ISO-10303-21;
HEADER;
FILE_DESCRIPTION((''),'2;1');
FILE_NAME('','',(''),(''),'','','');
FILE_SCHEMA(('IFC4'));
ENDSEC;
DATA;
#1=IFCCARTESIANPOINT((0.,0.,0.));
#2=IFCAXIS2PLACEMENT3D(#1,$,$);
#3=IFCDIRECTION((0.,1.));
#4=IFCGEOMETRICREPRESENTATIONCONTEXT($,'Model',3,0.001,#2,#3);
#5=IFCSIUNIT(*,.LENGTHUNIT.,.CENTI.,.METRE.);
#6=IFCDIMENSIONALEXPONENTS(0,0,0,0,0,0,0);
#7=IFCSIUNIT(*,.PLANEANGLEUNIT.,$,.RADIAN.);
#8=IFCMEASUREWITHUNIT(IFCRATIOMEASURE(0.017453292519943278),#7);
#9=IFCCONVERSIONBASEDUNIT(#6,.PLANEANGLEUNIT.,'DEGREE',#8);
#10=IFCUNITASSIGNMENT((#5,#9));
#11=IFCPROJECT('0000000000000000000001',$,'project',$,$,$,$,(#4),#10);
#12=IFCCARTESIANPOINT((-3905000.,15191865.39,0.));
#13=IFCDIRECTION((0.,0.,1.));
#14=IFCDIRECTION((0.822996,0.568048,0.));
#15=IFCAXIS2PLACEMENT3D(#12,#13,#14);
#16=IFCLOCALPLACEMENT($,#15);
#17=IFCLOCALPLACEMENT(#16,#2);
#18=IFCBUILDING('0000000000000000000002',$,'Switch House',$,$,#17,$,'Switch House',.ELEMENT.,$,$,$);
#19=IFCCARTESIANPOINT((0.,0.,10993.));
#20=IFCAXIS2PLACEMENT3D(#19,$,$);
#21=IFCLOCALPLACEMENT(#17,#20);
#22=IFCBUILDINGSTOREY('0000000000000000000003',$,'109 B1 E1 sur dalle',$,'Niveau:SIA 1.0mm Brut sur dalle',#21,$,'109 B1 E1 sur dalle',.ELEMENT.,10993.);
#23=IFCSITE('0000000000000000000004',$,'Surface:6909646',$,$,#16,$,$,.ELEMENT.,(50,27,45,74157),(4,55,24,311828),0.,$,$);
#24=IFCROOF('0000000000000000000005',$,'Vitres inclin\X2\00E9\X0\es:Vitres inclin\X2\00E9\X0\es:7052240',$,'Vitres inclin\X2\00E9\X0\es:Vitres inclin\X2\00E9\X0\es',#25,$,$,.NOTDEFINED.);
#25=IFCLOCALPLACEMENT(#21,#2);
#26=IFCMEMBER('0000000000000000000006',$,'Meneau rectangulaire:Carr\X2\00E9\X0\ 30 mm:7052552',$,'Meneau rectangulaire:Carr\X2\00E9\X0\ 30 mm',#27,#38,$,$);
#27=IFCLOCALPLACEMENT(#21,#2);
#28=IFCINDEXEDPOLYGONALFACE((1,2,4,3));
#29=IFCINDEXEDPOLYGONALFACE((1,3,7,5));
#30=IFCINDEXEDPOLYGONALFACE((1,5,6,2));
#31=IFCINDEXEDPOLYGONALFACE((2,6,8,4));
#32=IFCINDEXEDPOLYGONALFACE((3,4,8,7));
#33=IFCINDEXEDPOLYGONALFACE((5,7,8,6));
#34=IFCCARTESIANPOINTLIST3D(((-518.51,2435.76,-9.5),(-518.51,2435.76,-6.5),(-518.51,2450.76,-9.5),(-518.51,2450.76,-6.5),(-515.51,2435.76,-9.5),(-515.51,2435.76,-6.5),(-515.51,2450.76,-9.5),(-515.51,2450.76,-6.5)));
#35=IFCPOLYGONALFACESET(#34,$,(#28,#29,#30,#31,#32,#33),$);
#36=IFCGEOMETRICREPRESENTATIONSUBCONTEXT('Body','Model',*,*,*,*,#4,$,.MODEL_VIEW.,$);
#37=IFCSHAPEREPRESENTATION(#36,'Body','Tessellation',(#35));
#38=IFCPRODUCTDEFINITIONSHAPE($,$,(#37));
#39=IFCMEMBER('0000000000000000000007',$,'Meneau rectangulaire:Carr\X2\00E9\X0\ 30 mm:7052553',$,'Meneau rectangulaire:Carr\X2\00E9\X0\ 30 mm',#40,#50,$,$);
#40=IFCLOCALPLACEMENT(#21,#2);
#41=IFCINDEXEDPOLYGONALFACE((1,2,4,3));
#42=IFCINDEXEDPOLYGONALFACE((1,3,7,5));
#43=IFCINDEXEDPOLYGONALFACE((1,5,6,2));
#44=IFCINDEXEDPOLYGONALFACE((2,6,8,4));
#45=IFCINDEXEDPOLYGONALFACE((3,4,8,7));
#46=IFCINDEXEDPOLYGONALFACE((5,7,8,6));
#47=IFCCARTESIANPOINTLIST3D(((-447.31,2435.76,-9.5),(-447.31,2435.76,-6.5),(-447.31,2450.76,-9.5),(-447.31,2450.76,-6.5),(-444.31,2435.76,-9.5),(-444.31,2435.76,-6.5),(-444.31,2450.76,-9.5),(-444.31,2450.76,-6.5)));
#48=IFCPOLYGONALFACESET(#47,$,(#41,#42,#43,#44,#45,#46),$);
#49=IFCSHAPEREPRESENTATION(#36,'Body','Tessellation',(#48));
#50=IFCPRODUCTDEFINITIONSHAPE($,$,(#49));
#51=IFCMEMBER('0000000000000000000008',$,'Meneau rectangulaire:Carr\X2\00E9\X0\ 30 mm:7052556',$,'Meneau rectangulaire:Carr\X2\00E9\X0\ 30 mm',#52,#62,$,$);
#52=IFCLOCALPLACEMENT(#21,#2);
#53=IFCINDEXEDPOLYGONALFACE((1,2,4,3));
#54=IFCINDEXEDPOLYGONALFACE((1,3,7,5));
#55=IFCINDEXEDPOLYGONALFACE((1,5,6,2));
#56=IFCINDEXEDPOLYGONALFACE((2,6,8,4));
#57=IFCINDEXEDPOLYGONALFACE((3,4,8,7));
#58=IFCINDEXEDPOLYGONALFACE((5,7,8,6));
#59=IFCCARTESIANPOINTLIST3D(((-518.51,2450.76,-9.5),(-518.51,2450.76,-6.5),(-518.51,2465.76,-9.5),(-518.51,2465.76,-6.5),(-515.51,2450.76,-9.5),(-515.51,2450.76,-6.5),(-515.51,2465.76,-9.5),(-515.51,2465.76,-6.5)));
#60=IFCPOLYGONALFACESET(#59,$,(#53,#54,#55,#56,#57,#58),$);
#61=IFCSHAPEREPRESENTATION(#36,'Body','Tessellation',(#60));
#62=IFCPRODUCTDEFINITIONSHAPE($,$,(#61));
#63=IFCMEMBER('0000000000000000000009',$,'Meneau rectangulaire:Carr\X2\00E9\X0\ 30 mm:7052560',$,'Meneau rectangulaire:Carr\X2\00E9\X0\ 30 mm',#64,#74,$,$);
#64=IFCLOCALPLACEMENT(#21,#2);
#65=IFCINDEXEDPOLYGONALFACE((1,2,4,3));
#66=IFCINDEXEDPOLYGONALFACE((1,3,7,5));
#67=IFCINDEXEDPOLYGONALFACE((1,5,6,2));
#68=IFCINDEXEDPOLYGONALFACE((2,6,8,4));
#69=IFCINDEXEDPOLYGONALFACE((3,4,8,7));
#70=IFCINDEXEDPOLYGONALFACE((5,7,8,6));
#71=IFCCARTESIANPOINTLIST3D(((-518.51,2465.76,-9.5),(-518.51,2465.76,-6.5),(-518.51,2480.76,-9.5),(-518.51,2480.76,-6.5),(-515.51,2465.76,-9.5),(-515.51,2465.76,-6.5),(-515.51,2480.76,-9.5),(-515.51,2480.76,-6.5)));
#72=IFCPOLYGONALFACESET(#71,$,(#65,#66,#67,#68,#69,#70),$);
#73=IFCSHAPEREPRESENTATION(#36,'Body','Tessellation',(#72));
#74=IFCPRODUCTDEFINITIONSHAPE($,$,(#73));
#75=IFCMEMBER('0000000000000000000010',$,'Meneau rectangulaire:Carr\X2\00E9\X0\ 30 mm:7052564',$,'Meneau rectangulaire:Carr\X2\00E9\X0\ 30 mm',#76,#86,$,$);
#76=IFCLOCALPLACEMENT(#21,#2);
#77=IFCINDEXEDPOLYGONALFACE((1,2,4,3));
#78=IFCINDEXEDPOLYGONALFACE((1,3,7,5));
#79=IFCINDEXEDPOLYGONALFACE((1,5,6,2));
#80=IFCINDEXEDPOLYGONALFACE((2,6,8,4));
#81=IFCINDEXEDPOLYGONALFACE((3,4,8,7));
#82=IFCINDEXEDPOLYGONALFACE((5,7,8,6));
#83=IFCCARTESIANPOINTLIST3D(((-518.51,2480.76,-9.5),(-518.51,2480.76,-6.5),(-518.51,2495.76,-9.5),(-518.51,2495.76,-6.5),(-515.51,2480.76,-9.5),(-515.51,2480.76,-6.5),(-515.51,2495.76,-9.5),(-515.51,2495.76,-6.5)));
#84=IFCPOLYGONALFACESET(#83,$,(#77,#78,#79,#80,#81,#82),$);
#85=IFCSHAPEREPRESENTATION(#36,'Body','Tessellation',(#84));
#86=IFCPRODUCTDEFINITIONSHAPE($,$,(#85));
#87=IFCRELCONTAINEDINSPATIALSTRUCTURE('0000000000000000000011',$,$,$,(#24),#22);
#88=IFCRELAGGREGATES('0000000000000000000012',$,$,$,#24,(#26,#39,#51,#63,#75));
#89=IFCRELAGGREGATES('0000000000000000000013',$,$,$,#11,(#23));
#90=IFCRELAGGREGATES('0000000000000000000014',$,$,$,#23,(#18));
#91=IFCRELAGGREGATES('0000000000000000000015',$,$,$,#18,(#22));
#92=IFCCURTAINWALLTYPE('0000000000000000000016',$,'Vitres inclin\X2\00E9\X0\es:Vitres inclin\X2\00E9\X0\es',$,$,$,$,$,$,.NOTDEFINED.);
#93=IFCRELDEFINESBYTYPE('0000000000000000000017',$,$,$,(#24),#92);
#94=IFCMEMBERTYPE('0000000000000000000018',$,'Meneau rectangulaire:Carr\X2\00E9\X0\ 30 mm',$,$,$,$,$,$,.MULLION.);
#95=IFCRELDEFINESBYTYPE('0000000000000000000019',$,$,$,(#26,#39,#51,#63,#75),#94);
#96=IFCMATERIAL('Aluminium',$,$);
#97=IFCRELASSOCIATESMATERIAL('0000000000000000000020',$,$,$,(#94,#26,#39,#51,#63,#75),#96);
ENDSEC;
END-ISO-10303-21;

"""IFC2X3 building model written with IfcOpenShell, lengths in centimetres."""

from ifc_helpers import new_model, entity, si_unit, converted_unit, direction, frame, origin, origin_2d_with_axis, place, context, subcontext, project, spatial, rectangle, extrude, source, transform, mapped, material, type_object, type_shapes, element, aggregate, save


model = new_model("IFC2X3")

# Units and contexts
model_context = context("Model", 3, precision=0.001, world=origin(), true_north=direction((0.0, 1.0)))
body_context = subcontext(model_context, "Body", "Model", "MODEL_VIEW")
ifc_project = project(units=[si_unit("LENGTHUNIT", "METRE", prefix="CENTI"), converted_unit("PLANEANGLEUNIT", "DEGREE", entity("IfcRatioMeasure", 0.017453292519943278), si_unit("PLANEANGLEUNIT", "RADIAN"), dimensions=[0, 0, 0, 0, 0, 0, 0])], contexts=[model_context])

# Site, building, storey
site_placement = place(None, frame((-3905000.0, 15191865.39, 0.0), z_axis=(0.0, 0.0, 1.0), x_axis=(0.822996, 0.568048, 0.0)))
site = spatial("IfcSite", under=ifc_project, at=site_placement, Name="Surface:6909646", CompositionType="ELEMENT", RefLatitude=(50, 27, 45, 74157), RefLongitude=(4, 55, 24, 311828), RefElevation=0.0)
building_placement = place(site_placement, origin())
building = spatial("IfcBuilding", under=site, at=building_placement, Name="Switch House", LongName="Switch House", CompositionType="ELEMENT")
storey_placement = place(building_placement, frame((0.0, 0.0, 10993.0)))
storey = spatial("IfcBuildingStorey", under=building, at=storey_placement, Name="109 B1 E1 sur dalle", ObjectType="Niveau:SIA 1.0mm Brut sur dalle", LongName="109 B1 E1 sur dalle", CompositionType="ELEMENT", Elevation=10993.0)

# Roof, members
curtain_wall_type = type_object("IfcCurtainWallType", Name="Vitres inclinées:Vitres inclinées", PredefinedType="NOTDEFINED")
roof_placement = place(storey_placement, frame((0.0, 0.0, -10993.0)))
roof = element("IfcRoof", 1, at=roof_placement, inside=storey, type_object=curtain_wall_type, Name="Vitres inclinées:Vitres inclinées:7052240", ObjectType="Vitres inclinées:Vitres inclinées", ShapeType="NOTDEFINED")
ifc_material = material(Name="Aluminium")
member_type_1 = type_object("IfcMemberType", Name="Meneau rectangulaire:Carré 30 mm", PredefinedType="MULLION", material=ifc_material)
shared_shape_1 = source(origin(), body_context, "Body", "SweptSolid", [
    extrude(rectangle(XDim=3.0, YDim=3.0, at=origin_2d_with_axis()), frame((0.0, 0.0, -15.0), z_axis=(0.0, 0.0, 1.0), x_axis=(0.0, -1.0, 0.0)), (0.0, 0.0, 1.0), 15.0),
])
type_shapes(member_type_1, [shared_shape_1])
member_1_placement = place(roof_placement, frame((-517.01, 2450.76, 10985.0), z_axis=(0.0, 1.0, 0.0), x_axis=(1.0, 0.0, 0.0)))
member_1 = element("IfcMember", 2, at=member_1_placement, type_object=member_type_1, material=ifc_material, Name="Meneau rectangulaire:Carré 30 mm:7052552", ObjectType="Meneau rectangulaire:Carré 30 mm", context=body_context, shape_type="MappedRepresentation", body=[
    mapped(shared_shape_1, transform((0.0, 0.0, 0.0), scale=1.0)),
])
member_2_placement = place(roof_placement, frame((-445.81, 2450.76, 10985.0), z_axis=(0.0, 1.0, 0.0), x_axis=(1.0, 0.0, 0.0)))
member_2 = element("IfcMember", 3, at=member_2_placement, type_object=member_type_1, material=ifc_material, Name="Meneau rectangulaire:Carré 30 mm:7052553", ObjectType="Meneau rectangulaire:Carré 30 mm", context=body_context, shape_type="MappedRepresentation", body=[
    mapped(shared_shape_1, transform((0.0, 0.0, 0.0), scale=1.0)),
])
member_3_placement = place(roof_placement, frame((-517.01, 2465.76, 10985.0), z_axis=(0.0, 1.0, 0.0), x_axis=(1.0, 0.0, 0.0)))
member_3 = element("IfcMember", 4, at=member_3_placement, type_object=member_type_1, material=ifc_material, Name="Meneau rectangulaire:Carré 30 mm:7052556", ObjectType="Meneau rectangulaire:Carré 30 mm", context=body_context, shape_type="MappedRepresentation", body=[
    mapped(shared_shape_1, transform((0.0, 0.0, 0.0), scale=1.0)),
])
member_4_placement = place(roof_placement, frame((-517.01, 2480.76, 10985.0), z_axis=(0.0, 1.0, 0.0), x_axis=(1.0, 0.0, 0.0)))
member_4 = element("IfcMember", 5, at=member_4_placement, type_object=member_type_1, material=ifc_material, Name="Meneau rectangulaire:Carré 30 mm:7052560", ObjectType="Meneau rectangulaire:Carré 30 mm", context=body_context, shape_type="MappedRepresentation", body=[
    mapped(shared_shape_1, transform((0.0, 0.0, 0.0), scale=1.0)),
])
member_5_placement = place(roof_placement, frame((-517.01, 2495.76, 10985.0), z_axis=(0.0, 1.0, 0.0), x_axis=(1.0, 0.0, 0.0)))
member_5 = element("IfcMember", 6, at=member_5_placement, type_object=member_type_1, material=ifc_material, Name="Meneau rectangulaire:Carré 30 mm:7052564", ObjectType="Meneau rectangulaire:Carré 30 mm", context=body_context, shape_type="MappedRepresentation", body=[
    mapped(shared_shape_1, transform((0.0, 0.0, 0.0), scale=1.0)),
])
aggregate(roof, [member_1, member_2, member_3, member_4, member_5])

save(model, "model.ifc")
